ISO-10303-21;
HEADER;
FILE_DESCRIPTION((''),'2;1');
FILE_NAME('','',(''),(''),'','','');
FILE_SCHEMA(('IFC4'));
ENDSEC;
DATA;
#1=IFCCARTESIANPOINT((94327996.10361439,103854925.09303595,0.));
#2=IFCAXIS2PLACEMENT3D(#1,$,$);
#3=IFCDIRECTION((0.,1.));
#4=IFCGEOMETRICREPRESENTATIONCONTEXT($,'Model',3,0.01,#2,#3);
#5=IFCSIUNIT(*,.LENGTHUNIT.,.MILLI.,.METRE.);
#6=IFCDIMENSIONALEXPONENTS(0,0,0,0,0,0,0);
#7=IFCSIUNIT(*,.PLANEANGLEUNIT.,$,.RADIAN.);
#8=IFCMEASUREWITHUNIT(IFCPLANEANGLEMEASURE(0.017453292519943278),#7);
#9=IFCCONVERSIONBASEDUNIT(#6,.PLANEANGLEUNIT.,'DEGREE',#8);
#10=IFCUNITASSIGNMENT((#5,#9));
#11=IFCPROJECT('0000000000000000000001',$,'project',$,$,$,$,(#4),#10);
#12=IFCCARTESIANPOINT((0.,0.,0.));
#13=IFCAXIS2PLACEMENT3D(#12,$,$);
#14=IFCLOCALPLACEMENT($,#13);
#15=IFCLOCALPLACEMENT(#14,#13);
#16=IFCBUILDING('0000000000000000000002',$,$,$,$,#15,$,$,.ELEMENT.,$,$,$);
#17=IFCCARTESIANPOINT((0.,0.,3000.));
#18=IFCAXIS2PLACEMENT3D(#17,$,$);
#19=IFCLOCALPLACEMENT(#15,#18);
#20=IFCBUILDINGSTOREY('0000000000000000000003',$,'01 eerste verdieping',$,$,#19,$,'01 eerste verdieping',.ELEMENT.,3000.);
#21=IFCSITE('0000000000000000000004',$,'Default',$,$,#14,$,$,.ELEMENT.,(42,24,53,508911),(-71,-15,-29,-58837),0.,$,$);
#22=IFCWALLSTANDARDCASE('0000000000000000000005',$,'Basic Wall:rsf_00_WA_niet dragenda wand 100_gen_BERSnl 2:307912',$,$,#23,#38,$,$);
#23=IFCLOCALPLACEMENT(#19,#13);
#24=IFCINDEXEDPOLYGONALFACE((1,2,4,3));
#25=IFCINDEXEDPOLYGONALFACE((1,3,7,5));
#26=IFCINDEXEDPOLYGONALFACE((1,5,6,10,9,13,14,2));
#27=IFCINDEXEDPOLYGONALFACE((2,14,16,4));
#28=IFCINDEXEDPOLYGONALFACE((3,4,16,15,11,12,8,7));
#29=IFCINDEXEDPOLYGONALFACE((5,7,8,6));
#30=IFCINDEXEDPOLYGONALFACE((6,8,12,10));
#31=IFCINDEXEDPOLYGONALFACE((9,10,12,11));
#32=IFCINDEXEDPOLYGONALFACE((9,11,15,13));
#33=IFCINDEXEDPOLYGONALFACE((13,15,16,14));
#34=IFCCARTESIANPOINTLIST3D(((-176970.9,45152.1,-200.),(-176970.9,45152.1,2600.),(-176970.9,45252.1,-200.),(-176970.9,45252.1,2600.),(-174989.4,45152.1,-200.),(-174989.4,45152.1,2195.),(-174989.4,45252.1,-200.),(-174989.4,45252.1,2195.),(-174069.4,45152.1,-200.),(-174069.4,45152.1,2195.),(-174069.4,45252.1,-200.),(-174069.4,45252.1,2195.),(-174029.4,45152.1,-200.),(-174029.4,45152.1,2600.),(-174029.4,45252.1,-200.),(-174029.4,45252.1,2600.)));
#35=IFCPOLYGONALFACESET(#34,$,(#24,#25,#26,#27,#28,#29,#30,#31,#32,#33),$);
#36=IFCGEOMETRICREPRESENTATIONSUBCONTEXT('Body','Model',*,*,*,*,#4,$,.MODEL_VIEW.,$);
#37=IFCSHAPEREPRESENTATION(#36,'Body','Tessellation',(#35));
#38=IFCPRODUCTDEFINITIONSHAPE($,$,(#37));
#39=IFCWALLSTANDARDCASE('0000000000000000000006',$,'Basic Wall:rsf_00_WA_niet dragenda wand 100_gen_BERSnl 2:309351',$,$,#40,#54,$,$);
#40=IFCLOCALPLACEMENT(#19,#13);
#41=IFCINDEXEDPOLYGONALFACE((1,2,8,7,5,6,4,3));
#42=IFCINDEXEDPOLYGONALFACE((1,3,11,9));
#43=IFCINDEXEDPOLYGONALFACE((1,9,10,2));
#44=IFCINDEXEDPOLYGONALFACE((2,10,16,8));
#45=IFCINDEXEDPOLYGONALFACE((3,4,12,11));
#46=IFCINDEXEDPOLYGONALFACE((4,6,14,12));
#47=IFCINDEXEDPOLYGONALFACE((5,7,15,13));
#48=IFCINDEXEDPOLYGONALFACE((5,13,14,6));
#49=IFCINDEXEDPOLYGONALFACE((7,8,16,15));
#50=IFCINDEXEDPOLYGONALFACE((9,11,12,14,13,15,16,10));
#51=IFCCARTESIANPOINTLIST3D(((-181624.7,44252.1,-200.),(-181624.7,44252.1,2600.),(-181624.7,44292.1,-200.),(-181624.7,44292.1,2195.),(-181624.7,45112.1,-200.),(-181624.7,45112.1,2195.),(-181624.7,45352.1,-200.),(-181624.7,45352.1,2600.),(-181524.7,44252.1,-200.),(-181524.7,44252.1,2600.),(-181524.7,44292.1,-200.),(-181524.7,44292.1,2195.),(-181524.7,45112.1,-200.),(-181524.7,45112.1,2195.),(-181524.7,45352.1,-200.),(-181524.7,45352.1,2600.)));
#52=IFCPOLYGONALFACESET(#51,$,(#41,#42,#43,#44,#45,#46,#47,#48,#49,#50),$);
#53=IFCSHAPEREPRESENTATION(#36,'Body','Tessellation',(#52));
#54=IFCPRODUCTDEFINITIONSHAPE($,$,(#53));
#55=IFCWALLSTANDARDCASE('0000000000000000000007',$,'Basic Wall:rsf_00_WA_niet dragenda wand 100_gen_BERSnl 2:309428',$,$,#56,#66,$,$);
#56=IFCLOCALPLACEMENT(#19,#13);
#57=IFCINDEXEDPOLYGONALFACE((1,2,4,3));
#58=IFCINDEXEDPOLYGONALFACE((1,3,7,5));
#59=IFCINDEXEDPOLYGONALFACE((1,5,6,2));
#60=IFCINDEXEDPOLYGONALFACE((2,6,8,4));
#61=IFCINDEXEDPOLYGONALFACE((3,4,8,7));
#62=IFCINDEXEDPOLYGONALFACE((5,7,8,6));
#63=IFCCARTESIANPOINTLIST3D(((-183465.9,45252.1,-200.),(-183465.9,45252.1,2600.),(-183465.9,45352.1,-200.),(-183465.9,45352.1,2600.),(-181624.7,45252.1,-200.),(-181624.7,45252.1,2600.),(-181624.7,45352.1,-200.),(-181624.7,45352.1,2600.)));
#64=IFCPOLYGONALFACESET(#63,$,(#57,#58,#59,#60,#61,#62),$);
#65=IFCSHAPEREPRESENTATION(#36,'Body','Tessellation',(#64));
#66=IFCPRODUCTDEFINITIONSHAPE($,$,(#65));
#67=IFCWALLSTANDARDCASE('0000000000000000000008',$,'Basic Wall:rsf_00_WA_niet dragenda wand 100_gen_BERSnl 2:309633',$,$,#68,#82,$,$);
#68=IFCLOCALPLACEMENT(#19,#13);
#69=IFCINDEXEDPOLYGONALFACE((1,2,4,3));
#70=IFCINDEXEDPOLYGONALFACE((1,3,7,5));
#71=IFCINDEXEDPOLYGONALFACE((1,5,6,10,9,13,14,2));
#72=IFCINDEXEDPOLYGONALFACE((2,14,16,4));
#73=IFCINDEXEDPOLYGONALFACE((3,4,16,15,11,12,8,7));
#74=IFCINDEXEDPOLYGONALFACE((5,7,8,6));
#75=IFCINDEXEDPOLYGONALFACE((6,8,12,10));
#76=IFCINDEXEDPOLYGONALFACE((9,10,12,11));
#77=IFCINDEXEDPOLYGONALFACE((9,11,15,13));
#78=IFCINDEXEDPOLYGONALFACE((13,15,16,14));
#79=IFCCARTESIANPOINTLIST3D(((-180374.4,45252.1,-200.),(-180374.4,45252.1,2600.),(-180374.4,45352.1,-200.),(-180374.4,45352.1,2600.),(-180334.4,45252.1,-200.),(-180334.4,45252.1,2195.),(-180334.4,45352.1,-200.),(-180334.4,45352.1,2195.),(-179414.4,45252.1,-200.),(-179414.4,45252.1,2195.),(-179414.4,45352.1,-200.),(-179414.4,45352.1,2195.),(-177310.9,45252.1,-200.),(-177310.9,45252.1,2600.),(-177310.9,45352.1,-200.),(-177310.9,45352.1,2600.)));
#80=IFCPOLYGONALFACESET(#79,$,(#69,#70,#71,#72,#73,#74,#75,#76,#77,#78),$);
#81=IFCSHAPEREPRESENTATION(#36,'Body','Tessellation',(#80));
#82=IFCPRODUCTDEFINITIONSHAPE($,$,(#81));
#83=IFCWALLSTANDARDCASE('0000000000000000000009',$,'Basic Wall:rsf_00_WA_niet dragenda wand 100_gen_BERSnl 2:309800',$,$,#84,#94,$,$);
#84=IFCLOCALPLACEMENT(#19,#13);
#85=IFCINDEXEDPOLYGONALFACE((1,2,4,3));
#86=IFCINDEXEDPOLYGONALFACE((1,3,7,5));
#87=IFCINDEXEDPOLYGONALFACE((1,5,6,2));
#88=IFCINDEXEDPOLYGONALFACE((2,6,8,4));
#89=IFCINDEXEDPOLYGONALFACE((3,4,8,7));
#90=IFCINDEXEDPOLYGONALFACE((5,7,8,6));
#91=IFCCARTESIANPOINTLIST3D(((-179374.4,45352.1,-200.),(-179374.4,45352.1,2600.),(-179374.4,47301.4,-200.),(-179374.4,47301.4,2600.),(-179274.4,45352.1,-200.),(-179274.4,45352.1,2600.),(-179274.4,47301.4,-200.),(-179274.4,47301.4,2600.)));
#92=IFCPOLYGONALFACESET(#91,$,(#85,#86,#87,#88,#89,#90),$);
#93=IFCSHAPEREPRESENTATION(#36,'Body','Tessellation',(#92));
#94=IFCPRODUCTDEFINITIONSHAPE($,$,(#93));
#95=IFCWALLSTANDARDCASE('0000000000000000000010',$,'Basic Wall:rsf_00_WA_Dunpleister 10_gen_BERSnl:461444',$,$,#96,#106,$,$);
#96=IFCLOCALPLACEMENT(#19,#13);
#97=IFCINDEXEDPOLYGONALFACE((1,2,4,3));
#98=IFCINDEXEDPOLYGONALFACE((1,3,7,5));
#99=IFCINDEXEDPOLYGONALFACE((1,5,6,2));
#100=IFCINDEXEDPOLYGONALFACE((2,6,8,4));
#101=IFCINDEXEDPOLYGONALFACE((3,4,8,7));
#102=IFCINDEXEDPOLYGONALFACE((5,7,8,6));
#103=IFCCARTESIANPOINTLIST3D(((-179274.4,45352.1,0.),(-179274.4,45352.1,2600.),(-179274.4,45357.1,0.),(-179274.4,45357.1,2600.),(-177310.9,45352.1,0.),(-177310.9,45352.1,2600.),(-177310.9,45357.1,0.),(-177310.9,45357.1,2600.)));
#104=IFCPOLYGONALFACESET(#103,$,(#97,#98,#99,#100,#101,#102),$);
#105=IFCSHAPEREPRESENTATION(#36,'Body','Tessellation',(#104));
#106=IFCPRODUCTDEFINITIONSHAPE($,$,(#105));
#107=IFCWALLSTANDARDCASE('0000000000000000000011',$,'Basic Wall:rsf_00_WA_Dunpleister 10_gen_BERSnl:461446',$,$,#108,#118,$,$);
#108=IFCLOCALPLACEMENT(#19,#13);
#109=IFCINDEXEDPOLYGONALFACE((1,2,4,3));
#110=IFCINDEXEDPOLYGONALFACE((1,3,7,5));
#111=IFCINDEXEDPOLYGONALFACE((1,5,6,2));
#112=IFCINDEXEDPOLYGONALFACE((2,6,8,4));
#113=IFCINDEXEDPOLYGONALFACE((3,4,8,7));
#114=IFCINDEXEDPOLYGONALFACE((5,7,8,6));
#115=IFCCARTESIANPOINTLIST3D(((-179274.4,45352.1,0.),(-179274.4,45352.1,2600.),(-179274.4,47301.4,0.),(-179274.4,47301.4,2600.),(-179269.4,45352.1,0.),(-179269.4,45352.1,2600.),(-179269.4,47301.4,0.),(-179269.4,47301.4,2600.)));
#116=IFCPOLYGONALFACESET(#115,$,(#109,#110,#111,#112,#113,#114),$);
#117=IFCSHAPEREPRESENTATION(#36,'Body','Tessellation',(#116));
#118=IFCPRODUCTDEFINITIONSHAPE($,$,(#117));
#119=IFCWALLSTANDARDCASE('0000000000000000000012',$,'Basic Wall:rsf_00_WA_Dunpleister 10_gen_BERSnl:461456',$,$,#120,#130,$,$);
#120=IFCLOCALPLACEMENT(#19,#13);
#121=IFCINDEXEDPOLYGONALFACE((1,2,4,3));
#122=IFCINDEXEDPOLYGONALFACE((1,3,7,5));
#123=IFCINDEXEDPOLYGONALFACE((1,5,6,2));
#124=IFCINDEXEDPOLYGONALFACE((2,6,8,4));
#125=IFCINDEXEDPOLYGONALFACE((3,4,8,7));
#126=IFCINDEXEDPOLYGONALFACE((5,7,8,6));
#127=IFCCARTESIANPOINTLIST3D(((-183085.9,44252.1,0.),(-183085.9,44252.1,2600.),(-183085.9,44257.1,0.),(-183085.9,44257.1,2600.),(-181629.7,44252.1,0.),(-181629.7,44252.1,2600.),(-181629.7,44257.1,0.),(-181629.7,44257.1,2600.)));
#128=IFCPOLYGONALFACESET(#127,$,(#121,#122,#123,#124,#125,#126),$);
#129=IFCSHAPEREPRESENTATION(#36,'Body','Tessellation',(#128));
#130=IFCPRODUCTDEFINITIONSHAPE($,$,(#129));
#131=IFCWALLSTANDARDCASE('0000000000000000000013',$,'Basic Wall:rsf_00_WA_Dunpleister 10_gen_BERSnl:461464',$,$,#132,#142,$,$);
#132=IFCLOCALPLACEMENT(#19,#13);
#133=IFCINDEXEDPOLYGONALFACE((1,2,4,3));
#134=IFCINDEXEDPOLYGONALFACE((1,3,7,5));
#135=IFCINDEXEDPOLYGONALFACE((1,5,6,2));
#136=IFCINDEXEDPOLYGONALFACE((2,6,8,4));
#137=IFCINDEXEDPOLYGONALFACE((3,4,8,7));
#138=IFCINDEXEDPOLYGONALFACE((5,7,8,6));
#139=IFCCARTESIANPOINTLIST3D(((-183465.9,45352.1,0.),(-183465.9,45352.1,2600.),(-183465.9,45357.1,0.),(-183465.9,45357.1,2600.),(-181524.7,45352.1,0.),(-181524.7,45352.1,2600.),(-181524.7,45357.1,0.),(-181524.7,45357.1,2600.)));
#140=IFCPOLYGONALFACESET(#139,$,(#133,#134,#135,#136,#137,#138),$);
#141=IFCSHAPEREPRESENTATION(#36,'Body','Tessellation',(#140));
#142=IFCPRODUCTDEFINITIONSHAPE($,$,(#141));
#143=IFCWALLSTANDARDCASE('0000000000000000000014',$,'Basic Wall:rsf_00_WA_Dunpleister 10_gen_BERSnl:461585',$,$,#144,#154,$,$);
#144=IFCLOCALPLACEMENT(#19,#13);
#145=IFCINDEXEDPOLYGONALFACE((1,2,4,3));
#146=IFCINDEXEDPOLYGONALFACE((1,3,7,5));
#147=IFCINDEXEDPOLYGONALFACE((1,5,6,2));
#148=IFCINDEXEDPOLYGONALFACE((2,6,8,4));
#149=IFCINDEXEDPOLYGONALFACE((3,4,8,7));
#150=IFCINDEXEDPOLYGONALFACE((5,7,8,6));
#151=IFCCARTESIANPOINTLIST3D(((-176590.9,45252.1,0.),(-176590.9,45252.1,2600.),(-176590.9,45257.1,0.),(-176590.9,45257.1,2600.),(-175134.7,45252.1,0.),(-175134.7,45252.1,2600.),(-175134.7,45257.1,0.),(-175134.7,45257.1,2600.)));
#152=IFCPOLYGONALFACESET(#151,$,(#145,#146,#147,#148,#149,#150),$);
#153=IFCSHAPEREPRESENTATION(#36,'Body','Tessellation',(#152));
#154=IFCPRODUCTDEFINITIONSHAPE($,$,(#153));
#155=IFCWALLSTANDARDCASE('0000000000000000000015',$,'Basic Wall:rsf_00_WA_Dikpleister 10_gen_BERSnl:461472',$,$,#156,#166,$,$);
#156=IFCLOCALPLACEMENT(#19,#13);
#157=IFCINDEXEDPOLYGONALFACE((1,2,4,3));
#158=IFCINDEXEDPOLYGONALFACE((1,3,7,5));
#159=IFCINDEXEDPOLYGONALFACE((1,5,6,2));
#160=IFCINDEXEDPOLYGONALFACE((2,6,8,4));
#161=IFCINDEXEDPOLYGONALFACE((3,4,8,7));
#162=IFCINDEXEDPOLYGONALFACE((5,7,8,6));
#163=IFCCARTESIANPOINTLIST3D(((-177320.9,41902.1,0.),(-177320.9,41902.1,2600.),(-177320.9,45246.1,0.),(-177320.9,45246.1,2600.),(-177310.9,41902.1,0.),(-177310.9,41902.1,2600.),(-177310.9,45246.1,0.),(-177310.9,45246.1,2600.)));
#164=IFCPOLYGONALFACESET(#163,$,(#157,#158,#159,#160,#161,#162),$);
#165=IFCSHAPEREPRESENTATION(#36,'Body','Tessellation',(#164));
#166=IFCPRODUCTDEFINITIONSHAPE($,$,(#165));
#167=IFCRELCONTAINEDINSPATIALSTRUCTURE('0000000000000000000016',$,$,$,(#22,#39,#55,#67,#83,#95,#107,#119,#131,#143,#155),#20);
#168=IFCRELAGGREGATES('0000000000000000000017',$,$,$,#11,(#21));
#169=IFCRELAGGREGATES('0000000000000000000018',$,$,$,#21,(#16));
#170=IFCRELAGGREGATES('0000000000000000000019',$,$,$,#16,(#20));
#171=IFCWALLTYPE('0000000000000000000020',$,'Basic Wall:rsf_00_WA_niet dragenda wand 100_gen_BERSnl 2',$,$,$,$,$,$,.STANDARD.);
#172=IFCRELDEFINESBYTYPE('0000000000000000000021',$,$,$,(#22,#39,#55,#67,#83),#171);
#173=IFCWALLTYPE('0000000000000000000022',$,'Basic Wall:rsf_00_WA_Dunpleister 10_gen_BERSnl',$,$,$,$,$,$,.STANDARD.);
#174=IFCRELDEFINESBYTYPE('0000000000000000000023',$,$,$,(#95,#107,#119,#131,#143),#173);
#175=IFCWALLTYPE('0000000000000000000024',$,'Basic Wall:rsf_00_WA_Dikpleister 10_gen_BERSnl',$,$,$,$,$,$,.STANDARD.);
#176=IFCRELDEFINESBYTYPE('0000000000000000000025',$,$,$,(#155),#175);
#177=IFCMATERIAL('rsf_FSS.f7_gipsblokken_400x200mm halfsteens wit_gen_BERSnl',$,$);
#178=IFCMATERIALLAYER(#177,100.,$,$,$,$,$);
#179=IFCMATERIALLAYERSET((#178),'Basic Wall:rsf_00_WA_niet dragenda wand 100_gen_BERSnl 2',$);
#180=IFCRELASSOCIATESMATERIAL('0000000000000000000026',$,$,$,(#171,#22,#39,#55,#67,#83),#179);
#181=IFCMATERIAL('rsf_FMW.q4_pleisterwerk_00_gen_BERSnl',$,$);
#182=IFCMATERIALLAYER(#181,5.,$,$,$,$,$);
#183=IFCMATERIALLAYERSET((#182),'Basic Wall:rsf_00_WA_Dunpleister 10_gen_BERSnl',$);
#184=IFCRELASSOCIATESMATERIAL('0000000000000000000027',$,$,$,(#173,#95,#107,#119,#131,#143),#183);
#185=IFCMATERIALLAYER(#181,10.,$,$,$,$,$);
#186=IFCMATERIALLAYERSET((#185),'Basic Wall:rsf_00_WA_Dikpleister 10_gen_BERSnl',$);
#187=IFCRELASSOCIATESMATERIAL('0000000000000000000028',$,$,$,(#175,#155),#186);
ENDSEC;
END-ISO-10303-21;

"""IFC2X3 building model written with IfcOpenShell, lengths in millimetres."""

from ifc_helpers import new_model, entity, si_unit, converted_unit, direction, frame, frame_2d, origin, place, context, subcontext, project, spatial, rectangle, extrude, material, layer, layer_set, layer_usage, type_object, element, save


model = new_model("IFC2X3")

# Units and contexts
model_context = context("Model", 3, precision=0.01, world=frame((94327996.10361439, 103854925.09303595, 0.0)), true_north=direction((0.0, 1.0)))
body_context = subcontext(model_context, "Body", "Model", "MODEL_VIEW")
ifc_project = project(units=[si_unit("LENGTHUNIT", "METRE", prefix="MILLI"), converted_unit("PLANEANGLEUNIT", "DEGREE", entity("IfcPlaneAngleMeasure", 0.017453292519943278), si_unit("PLANEANGLEUNIT", "RADIAN"), dimensions=[0, 0, 0, 0, 0, 0, 0])], contexts=[model_context])

# Site, building, storey
site_placement = place(None, origin())
site = spatial("IfcSite", under=ifc_project, at=site_placement, Name="Default", CompositionType="ELEMENT", RefLatitude=(42, 24, 53, 508911), RefLongitude=(-71, -15, -29, -58837), RefElevation=0.0)
building_placement = place(site_placement, origin())
building = spatial("IfcBuilding", under=site, at=building_placement, CompositionType="ELEMENT")
storey_placement = place(building_placement, frame((0.0, 0.0, 3000.0)))
storey = spatial("IfcBuildingStorey", under=building, at=storey_placement, Name="01 eerste verdieping", LongName="01 eerste verdieping", CompositionType="ELEMENT", Elevation=3000.0)

# Walls, openings
ifc_material_1 = material(Name="rsf_FSS.f7_gipsblokken_400x200mm halfsteens wit_gen_BERSnl")
ifc_layer_1 = layer(ifc_material_1, 100.0)
ifc_layer_set_1 = layer_set([ifc_layer_1], Name="Basic Wall:rsf_00_WA_niet dragenda wand 100_gen_BERSnl 2")
ifc_layer_usage_1 = layer_usage(ifc_layer_set_1, "AXIS2", "NEGATIVE", 50.0)
wall_type_1 = type_object("IfcWallType", Name="Basic Wall:rsf_00_WA_niet dragenda wand 100_gen_BERSnl 2", PredefinedType="STANDARD", material=ifc_layer_set_1)
wall_1_placement = place(storey_placement, frame((-176970.9, 45202.1, -200.0)))
wall_1 = element("IfcWallStandardCase", 1, at=wall_1_placement, inside=storey, type_object=wall_type_1, material=ifc_layer_usage_1, Name="Basic Wall:rsf_00_WA_niet dragenda wand 100_gen_BERSnl 2:307912", context=body_context, shape_type="SweptSolid", body=[
    extrude(rectangle(XDim=2941.5, YDim=100.0, at=frame_2d((1470.8, 0.0), x_axis=(1.0, 0.0))), origin(), (0.0, 0.0, 1.0), 2800.0),
])
opening_1_placement = place(wall_1_placement, frame((2901.5, 50.0, 0.0)))
element("IfcOpeningElement", 2, at=opening_1_placement, cuts=wall_1, ObjectType="Opening", context=body_context, shape_type="SweptSolid", body=[
    extrude(rectangle(XDim=2395.0, YDim=920.0, at=frame_2d((1197.5, 460.0), x_axis=(-1.0, 0.0))), frame((0.0, 0.0, 0.0), z_axis=(0.0, -1.0, 0.0), x_axis=(0.0, 0.0, 1.0)), (0.0, 0.0, 1.0), 100.0),
])
ifc_layer_usage_2 = layer_usage(ifc_layer_set_1, "AXIS2", "NEGATIVE", 50.0)
wall_2_placement = place(storey_placement, frame((-181574.7, 44252.1, -200.0), z_axis=(0.0, 0.0, 1.0), x_axis=(0.0, 1.0, 0.0)))
wall_2 = element("IfcWallStandardCase", 3, at=wall_2_placement, inside=storey, type_object=wall_type_1, material=ifc_layer_usage_2, Name="Basic Wall:rsf_00_WA_niet dragenda wand 100_gen_BERSnl 2:309351", context=body_context, shape_type="SweptSolid", body=[
    extrude(rectangle(XDim=1100.0, YDim=100.0, at=frame_2d((550.0, 0.0), x_axis=(1.0, 0.0))), origin(), (0.0, 0.0, 1.0), 2800.0),
])
opening_2_placement = place(wall_2_placement, frame((860.0, 50.0, 0.0)))
element("IfcOpeningElement", 4, at=opening_2_placement, cuts=wall_2, ObjectType="Opening", context=body_context, shape_type="SweptSolid", body=[
    extrude(rectangle(XDim=2395.0, YDim=820.0, at=frame_2d((1197.5, 410.0), x_axis=(-1.0, 0.0))), frame((0.0, 0.0, 0.0), z_axis=(0.0, -1.0, 0.0), x_axis=(0.0, 0.0, 1.0)), (0.0, 0.0, 1.0), 100.0),
])

# Wall
ifc_layer_usage_3 = layer_usage(ifc_layer_set_1, "AXIS2", "NEGATIVE", 50.0)
wall_3_placement = place(storey_placement, frame((-181624.7, 45302.1, -200.0), z_axis=(0.0, 0.0, 1.0), x_axis=(-1.0, 0.0, 0.0)))
element("IfcWallStandardCase", 5, at=wall_3_placement, inside=storey, type_object=wall_type_1, material=ifc_layer_usage_3, Name="Basic Wall:rsf_00_WA_niet dragenda wand 100_gen_BERSnl 2:309428", context=body_context, shape_type="SweptSolid", body=[
    extrude(rectangle(XDim=1841.2, YDim=100.0, at=frame_2d((920.6, 0.0), x_axis=(-1.0, 0.0))), origin(), (0.0, 0.0, 1.0), 2800.0),
])

# Wall, opening
ifc_layer_usage_4 = layer_usage(ifc_layer_set_1, "AXIS2", "POSITIVE", -50.0)
wall_4_placement = place(storey_placement, frame((-177310.9, 45302.1, -200.0), z_axis=(0.0, 0.0, 1.0), x_axis=(-1.0, 0.0, 0.0)))
wall_4 = element("IfcWallStandardCase", 6, at=wall_4_placement, inside=storey, type_object=wall_type_1, material=ifc_layer_usage_4, Name="Basic Wall:rsf_00_WA_niet dragenda wand 100_gen_BERSnl 2:309633", context=body_context, shape_type="SweptSolid", body=[
    extrude(rectangle(XDim=3063.5, YDim=100.0, at=frame_2d((1531.7, 0.0), x_axis=(1.0, 0.0))), origin(), (0.0, 0.0, 1.0), 2800.0),
])
opening_3_placement = place(wall_4_placement, frame((3023.5, 50.0, 0.0)))
element("IfcOpeningElement", 7, at=opening_3_placement, cuts=wall_4, ObjectType="Opening", context=body_context, shape_type="SweptSolid", body=[
    extrude(rectangle(XDim=2395.0, YDim=920.0, at=frame_2d((1197.5, 460.0), x_axis=(-1.0, 0.0))), frame((0.0, 0.0, 0.0), z_axis=(0.0, -1.0, 0.0), x_axis=(0.0, 0.0, 1.0)), (0.0, 0.0, 1.0), 100.0),
])

# Wall
ifc_layer_usage_5 = layer_usage(ifc_layer_set_1, "AXIS2", "NEGATIVE", 50.0)
wall_5_placement = place(storey_placement, frame((-179324.4, 45352.1, -200.0), z_axis=(0.0, 0.0, 1.0), x_axis=(0.0, 1.0, 0.0)))
element("IfcWallStandardCase", 8, at=wall_5_placement, inside=storey, type_object=wall_type_1, material=ifc_layer_usage_5, Name="Basic Wall:rsf_00_WA_niet dragenda wand 100_gen_BERSnl 2:309800", context=body_context, shape_type="SweptSolid", body=[
    extrude(rectangle(XDim=1949.4, YDim=100.0, at=frame_2d((974.7, 0.0), x_axis=(-1.0, 0.0))), origin(), (0.0, 0.0, 1.0), 2800.0),
])

# Shared definitions
ifc_material_2 = material(Name="rsf_FMW.q4_pleisterwerk_00_gen_BERSnl")
ifc_layer_2 = layer(ifc_material_2, 5.0)
ifc_layer_set_2 = layer_set([ifc_layer_2], Name="Basic Wall:rsf_00_WA_Dunpleister 10_gen_BERSnl")
wall_type_2 = type_object("IfcWallType", Name="Basic Wall:rsf_00_WA_Dunpleister 10_gen_BERSnl", PredefinedType="STANDARD", material=ifc_layer_set_2)

# Walls
ifc_layer_usage_6 = layer_usage(ifc_layer_set_2, "AXIS2", "POSITIVE", -2.5)
wall_6_placement = place(storey_placement, frame((-177310.9, 45354.6, 0.0), z_axis=(0.0, 0.0, 1.0), x_axis=(-1.0, 0.0, 0.0)))
element("IfcWallStandardCase", 9, at=wall_6_placement, inside=storey, type_object=wall_type_2, material=ifc_layer_usage_6, Name="Basic Wall:rsf_00_WA_Dunpleister 10_gen_BERSnl:461444", context=body_context, shape_type="SweptSolid", body=[
    extrude(rectangle(XDim=1963.5, YDim=5.0, at=frame_2d((981.7, 0.0), x_axis=(-1.0, 0.0))), origin(), (0.0, 0.0, 1.0), 2600.0),
])
ifc_layer_usage_7 = layer_usage(ifc_layer_set_2, "AXIS2", "POSITIVE", -2.5)
wall_7_placement = place(storey_placement, frame((-179271.9, 45352.1, 0.0), z_axis=(0.0, 0.0, 1.0), x_axis=(0.0, 1.0, 0.0)))
element("IfcWallStandardCase", 10, at=wall_7_placement, inside=storey, type_object=wall_type_2, material=ifc_layer_usage_7, Name="Basic Wall:rsf_00_WA_Dunpleister 10_gen_BERSnl:461446", context=body_context, shape_type="SweptSolid", body=[
    extrude(rectangle(XDim=1949.4, YDim=5.0, at=frame_2d((974.7, 0.0), x_axis=(-1.0, 0.0))), origin(), (0.0, 0.0, 1.0), 2600.0),
])

# Wall
ifc_layer_usage_8 = layer_usage(ifc_layer_set_2, "AXIS2", "POSITIVE", -2.5)
wall_8_placement = place(storey_placement, frame((-181629.7, 44254.6, 0.0), z_axis=(0.0, 0.0, 1.0), x_axis=(-1.0, 0.0, 0.0)))
element("IfcWallStandardCase", 11, at=wall_8_placement, inside=storey, type_object=wall_type_2, material=ifc_layer_usage_8, Name="Basic Wall:rsf_00_WA_Dunpleister 10_gen_BERSnl:461456", context=body_context, shape_type="SweptSolid", body=[
    extrude(rectangle(XDim=1456.2, YDim=5.0, at=frame_2d((728.1, 0.0), x_axis=(-1.0, 0.0))), origin(), (0.0, 0.0, 1.0), 2600.0),
])

# Walls
ifc_layer_usage_9 = layer_usage(ifc_layer_set_2, "AXIS2", "POSITIVE", -2.5)
wall_9_placement = place(storey_placement, frame((-181524.7, 45354.6, 0.0), z_axis=(0.0, 0.0, 1.0), x_axis=(-1.0, 0.0, 0.0)))
element("IfcWallStandardCase", 12, at=wall_9_placement, inside=storey, type_object=wall_type_2, material=ifc_layer_usage_9, Name="Basic Wall:rsf_00_WA_Dunpleister 10_gen_BERSnl:461464", context=body_context, shape_type="SweptSolid", body=[
    extrude(rectangle(XDim=1941.2, YDim=5.0, at=frame_2d((970.6, 0.0), x_axis=(-1.0, 0.0))), origin(), (0.0, 0.0, 1.0), 2600.0),
])
ifc_layer_usage_10 = layer_usage(ifc_layer_set_2, "AXIS2", "POSITIVE", -2.5)
wall_10_placement = place(storey_placement, frame((-175134.7, 45254.6, 0.0), z_axis=(0.0, 0.0, 1.0), x_axis=(-1.0, 0.0, 0.0)))
element("IfcWallStandardCase", 13, at=wall_10_placement, inside=storey, type_object=wall_type_2, material=ifc_layer_usage_10, Name="Basic Wall:rsf_00_WA_Dunpleister 10_gen_BERSnl:461585", context=body_context, shape_type="SweptSolid", body=[
    extrude(rectangle(XDim=1456.2, YDim=5.0, at=frame_2d((728.1, 0.0), x_axis=(-1.0, 0.0))), origin(), (0.0, 0.0, 1.0), 2600.0),
])

# Wall
ifc_layer_3 = layer(ifc_material_2, 10.0)
ifc_layer_set_3 = layer_set([ifc_layer_3], Name="Basic Wall:rsf_00_WA_Dikpleister 10_gen_BERSnl")
ifc_layer_usage_11 = layer_usage(ifc_layer_set_3, "AXIS2", "POSITIVE", -5.0)
wall_type_3 = type_object("IfcWallType", Name="Basic Wall:rsf_00_WA_Dikpleister 10_gen_BERSnl", PredefinedType="STANDARD", material=ifc_layer_set_3)
wall_11_placement = place(storey_placement, frame((-177315.9, 45246.1, 0.0), z_axis=(0.0, 0.0, 1.0), x_axis=(0.0, -1.0, 0.0)))
element("IfcWallStandardCase", 14, at=wall_11_placement, inside=storey, type_object=wall_type_3, material=ifc_layer_usage_11, Name="Basic Wall:rsf_00_WA_Dikpleister 10_gen_BERSnl:461472", context=body_context, shape_type="SweptSolid", body=[
    extrude(rectangle(XDim=3344.0, YDim=10.0, at=frame_2d((1672.0, 0.0), x_axis=(-1.0, 0.0))), origin(), (0.0, 0.0, 1.0), 2600.0),
])

save(model, "model.ifc")
